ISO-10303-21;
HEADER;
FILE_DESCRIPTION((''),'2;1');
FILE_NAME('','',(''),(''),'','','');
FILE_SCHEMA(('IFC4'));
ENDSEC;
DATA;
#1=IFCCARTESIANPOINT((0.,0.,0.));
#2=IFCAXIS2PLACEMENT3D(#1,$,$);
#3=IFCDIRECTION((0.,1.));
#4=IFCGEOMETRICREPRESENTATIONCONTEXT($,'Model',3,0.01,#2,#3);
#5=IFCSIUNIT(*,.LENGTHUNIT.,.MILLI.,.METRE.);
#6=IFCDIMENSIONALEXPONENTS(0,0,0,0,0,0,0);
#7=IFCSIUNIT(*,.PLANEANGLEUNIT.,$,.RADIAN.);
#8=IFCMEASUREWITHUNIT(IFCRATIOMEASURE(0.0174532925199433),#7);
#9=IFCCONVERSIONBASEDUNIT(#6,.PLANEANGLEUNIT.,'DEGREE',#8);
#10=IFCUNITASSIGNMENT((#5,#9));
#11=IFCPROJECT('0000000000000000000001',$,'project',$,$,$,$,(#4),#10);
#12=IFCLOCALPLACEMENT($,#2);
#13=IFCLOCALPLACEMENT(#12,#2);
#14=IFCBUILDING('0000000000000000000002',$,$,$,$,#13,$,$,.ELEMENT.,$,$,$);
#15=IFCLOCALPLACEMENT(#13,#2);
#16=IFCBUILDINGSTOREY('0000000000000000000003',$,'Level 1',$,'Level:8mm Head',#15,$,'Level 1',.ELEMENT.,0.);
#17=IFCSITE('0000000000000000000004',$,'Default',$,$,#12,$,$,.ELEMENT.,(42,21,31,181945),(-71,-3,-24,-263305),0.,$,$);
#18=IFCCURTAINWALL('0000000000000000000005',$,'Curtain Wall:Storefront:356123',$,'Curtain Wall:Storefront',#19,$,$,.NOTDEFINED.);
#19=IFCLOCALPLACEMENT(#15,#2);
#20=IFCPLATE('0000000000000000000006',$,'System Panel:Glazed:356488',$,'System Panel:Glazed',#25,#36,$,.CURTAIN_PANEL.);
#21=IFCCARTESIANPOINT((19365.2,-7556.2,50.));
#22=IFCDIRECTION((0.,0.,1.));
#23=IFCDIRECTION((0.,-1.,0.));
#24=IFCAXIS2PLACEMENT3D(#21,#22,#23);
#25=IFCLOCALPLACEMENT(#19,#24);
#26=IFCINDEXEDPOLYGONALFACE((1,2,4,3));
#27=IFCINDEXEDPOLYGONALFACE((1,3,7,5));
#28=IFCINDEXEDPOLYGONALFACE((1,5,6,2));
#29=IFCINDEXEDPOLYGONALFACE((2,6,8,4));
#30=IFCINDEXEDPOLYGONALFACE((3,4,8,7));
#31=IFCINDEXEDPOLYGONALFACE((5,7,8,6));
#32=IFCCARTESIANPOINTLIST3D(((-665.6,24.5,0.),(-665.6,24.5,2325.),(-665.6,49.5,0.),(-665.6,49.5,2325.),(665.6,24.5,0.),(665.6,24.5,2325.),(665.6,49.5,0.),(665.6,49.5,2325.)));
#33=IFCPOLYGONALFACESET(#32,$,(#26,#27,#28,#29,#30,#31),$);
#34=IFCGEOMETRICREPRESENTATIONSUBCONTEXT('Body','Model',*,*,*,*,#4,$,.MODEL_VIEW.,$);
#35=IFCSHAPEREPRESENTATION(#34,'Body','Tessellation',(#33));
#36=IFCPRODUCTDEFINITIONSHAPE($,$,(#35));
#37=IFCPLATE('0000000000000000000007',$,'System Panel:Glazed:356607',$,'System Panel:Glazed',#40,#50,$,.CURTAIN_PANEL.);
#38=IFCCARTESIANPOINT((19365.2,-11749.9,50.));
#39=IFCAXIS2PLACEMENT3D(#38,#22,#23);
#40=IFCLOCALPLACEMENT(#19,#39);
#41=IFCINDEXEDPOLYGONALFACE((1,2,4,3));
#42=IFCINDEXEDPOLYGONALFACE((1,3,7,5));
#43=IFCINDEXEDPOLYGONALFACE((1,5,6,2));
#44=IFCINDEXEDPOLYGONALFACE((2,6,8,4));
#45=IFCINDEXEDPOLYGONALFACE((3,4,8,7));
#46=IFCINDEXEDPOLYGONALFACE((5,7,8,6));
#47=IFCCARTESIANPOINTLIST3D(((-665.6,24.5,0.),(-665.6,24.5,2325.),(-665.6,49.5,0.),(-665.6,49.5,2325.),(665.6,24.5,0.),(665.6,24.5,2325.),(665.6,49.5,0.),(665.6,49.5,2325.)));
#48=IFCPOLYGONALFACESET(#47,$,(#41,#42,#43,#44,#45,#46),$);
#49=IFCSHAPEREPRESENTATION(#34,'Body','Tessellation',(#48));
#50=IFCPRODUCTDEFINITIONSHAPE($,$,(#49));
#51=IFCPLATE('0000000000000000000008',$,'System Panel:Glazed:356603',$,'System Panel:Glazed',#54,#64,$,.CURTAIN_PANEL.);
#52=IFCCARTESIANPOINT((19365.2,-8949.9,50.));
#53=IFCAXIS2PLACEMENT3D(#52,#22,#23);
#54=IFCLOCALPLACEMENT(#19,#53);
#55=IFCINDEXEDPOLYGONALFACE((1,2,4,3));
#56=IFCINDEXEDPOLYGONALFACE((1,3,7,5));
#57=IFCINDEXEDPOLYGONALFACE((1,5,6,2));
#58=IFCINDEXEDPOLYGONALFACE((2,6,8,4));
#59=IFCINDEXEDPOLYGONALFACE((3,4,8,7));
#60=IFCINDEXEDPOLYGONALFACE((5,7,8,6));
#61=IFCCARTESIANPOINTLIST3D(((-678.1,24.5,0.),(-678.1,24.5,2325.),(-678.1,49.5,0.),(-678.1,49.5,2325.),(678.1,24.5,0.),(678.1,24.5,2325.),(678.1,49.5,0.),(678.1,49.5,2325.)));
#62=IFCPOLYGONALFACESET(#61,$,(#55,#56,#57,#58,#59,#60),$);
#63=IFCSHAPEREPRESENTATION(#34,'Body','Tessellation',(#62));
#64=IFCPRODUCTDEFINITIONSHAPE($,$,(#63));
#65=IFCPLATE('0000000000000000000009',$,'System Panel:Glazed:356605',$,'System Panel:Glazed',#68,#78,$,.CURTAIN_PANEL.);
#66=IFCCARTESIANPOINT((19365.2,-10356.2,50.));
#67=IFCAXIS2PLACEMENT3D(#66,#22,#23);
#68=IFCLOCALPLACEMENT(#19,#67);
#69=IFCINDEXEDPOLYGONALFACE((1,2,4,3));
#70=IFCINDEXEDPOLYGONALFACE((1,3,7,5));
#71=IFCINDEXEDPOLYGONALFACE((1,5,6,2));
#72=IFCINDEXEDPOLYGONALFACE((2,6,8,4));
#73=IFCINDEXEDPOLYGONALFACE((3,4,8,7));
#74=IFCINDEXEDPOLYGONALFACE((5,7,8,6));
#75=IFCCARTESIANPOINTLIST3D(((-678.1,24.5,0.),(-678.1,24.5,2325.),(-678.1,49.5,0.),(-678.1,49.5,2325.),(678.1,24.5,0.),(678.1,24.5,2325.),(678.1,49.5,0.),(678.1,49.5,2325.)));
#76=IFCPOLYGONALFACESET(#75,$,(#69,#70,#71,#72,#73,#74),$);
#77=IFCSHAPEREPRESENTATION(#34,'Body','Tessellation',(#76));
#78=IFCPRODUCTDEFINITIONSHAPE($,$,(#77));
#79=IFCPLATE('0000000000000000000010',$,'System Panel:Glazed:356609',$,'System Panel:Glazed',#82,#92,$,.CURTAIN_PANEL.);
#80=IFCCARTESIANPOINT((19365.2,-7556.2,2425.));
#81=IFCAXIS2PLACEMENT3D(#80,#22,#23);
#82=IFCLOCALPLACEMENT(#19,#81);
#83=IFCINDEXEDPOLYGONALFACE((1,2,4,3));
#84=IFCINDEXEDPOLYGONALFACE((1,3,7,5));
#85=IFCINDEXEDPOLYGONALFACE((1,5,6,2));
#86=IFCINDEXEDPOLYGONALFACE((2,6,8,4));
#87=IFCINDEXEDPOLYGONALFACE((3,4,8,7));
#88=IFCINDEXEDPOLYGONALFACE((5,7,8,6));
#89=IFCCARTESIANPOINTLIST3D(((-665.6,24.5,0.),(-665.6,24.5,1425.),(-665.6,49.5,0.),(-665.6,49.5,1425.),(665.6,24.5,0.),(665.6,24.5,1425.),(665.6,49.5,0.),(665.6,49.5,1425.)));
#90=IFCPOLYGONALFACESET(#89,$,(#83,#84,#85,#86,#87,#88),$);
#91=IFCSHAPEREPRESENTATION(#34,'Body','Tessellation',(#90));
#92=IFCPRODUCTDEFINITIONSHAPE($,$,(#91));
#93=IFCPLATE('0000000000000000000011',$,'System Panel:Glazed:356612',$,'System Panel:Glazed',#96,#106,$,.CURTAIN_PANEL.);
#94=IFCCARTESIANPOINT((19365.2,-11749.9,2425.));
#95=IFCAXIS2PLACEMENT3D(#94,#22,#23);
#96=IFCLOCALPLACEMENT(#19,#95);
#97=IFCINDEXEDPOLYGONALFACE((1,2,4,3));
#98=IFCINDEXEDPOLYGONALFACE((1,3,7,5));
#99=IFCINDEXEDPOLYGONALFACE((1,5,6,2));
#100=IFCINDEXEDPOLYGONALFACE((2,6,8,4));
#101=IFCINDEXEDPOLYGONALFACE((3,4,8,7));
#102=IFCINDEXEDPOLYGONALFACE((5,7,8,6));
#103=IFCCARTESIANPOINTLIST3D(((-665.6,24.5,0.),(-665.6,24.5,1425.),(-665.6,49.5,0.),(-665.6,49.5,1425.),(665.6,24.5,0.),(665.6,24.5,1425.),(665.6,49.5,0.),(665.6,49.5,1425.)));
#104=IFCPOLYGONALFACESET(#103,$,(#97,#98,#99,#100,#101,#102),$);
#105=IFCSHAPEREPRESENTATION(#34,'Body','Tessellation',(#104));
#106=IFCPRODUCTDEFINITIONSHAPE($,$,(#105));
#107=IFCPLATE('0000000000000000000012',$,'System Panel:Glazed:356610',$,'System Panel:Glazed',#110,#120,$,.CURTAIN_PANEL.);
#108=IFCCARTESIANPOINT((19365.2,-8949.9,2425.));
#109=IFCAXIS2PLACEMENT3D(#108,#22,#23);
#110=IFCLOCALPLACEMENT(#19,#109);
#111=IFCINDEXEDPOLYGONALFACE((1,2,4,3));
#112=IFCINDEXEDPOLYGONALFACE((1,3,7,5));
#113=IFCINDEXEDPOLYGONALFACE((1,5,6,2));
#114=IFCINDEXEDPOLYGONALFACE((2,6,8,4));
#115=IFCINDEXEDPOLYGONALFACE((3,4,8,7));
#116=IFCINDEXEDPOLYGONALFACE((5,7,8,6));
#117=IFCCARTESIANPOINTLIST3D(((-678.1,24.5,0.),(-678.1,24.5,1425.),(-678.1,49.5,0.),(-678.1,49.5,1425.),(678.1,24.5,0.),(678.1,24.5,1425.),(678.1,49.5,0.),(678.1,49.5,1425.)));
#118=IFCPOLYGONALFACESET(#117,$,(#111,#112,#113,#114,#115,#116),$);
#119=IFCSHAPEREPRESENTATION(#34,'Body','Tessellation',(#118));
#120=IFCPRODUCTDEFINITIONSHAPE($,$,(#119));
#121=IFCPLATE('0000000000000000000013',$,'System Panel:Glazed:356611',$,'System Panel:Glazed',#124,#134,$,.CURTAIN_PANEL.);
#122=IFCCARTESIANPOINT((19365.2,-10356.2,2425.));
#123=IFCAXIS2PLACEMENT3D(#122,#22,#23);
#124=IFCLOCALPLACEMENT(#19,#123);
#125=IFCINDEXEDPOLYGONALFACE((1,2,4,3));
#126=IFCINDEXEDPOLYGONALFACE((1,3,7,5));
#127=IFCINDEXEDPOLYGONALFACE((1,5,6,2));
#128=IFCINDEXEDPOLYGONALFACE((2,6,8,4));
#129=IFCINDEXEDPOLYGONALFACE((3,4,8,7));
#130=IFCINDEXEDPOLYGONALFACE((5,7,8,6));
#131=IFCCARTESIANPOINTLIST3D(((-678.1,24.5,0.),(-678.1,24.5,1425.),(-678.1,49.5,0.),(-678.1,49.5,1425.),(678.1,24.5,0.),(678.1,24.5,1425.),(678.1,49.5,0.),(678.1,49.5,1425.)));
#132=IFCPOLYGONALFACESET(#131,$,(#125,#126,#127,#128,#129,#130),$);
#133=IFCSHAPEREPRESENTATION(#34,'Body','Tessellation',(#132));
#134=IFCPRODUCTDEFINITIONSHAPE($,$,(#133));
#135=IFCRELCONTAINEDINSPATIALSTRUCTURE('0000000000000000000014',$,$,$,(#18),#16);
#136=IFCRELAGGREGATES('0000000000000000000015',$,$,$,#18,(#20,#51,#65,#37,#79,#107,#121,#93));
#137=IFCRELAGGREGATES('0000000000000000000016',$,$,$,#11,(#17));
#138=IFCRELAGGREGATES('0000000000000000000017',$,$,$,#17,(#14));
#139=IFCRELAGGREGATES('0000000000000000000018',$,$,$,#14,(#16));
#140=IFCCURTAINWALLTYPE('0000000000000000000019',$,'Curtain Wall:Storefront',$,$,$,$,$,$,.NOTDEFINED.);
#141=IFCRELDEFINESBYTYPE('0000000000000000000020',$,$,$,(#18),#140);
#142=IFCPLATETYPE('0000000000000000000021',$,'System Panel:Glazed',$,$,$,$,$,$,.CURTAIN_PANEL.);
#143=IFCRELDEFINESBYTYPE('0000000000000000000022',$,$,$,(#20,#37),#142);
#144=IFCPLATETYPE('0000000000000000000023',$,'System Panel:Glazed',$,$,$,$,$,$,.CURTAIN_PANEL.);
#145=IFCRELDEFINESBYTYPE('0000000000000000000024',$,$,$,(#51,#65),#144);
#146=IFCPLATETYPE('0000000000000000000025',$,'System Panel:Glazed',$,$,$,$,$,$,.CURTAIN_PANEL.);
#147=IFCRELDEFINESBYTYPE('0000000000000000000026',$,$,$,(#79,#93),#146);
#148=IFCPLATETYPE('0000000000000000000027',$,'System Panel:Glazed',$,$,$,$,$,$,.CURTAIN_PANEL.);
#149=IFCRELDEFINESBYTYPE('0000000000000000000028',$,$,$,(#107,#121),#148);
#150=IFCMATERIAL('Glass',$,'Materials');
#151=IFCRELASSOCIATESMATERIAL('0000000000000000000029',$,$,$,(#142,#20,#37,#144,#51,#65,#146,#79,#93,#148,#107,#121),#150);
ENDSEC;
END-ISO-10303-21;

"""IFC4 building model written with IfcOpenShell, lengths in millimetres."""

from ifc_helpers import new_model, entity, si_unit, converted_unit, direction, frame, origin, place, context, subcontext, project, spatial, indexed_curve, outline, extrude, shape, source, transform, mapped, material, type_object, type_shapes, element, aggregate, save


model = new_model("IFC4")

# Units and contexts
model_context = context("Model", 3, precision=0.01, world=origin(), true_north=direction((0.0, 1.0)))
body_context = subcontext(model_context, "Body", "Model", "MODEL_VIEW")
footprint_context = subcontext(model_context, "FootPrint", "Model", "MODEL_VIEW")
ifc_project = project(units=[si_unit("LENGTHUNIT", "METRE", prefix="MILLI"), converted_unit("PLANEANGLEUNIT", "DEGREE", entity("IfcRatioMeasure", 0.0174532925199433), si_unit("PLANEANGLEUNIT", "RADIAN"), dimensions=[0, 0, 0, 0, 0, 0, 0])], contexts=[model_context])

# Site, building, storey
site_placement = place(None, origin())
site = spatial("IfcSite", under=ifc_project, at=site_placement, Name="Default", CompositionType="ELEMENT", RefLatitude=(42, 21, 31, 181945), RefLongitude=(-71, -3, -24, -263305), RefElevation=0.0)
building_placement = place(site_placement, origin())
building = spatial("IfcBuilding", under=site, at=building_placement, CompositionType="ELEMENT")
storey_placement = place(building_placement, origin())
storey = spatial("IfcBuildingStorey", under=building, at=storey_placement, Name="Level 1", ObjectType="Level:8mm Head", LongName="Level 1", CompositionType="ELEMENT", Elevation=0.0)

# Shared definitions
curtain_wall_type_1 = type_object("IfcCurtainWallType", Name="Curtain Wall:Storefront", PredefinedType="NOTDEFINED")

# Curtain wall
curtain_wall_1_placement = place(storey_placement, origin())
curtain_wall_1 = element("IfcCurtainWall", 1, at=curtain_wall_1_placement, inside=storey, type_object=curtain_wall_type_1, Name="Curtain Wall:Storefront:356123", ObjectType="Curtain Wall:Storefront", PredefinedType="NOTDEFINED")

# Plates
ifc_material_1 = material(Name="Glass", Category="Materials")
plate_type_1 = type_object("IfcPlateType", Name="System Panel:Glazed", PredefinedType="CURTAIN_PANEL", material=ifc_material_1)
shared_shape_1 = source(origin(), body_context, "Body", "SweptSolid", [
    extrude(outline(indexed_curve([(-12.5, -665.6), (12.5, -665.6), (12.5, 665.6), (-12.5, 665.6), (-12.5, -665.6)], self_intersect=False)), frame((0.0, 37.0, 0.0), z_axis=(0.0, 0.0, 1.0), x_axis=(0.0, 1.0, 0.0)), (0.0, 0.0, 1.0), 2325.0),
])
shared_shape_2 = source(origin(), footprint_context, "FootPrint", "Curve2D", [
    entity("IfcIndexedPolyCurve", entity("IfcCartesianPointList2D", [[665.6, 24.5], [665.6, 49.5], [-665.6, 49.5], [-665.6, 24.5], [665.6, 24.5]]), None, False),
])
type_shapes(plate_type_1, [shared_shape_1, shared_shape_2])
plate_1_placement = place(curtain_wall_1_placement, frame((19365.2, -7556.2, 50.0), z_axis=(0.0, 0.0, 1.0), x_axis=(0.0, -1.0, 0.0)))
plate_1 = element("IfcPlate", 2, at=plate_1_placement, type_object=plate_type_1, material=ifc_material_1, Name="System Panel:Glazed:356488", ObjectType="System Panel:Glazed", PredefinedType="CURTAIN_PANEL", shapes=[
    shape(body_context, "Body", "MappedRepresentation", [mapped(shared_shape_1, transform((0.0, 0.0, 0.0), scale=1.0))]),
    shape(body_context, "Body", "MappedRepresentation", [mapped(shared_shape_2, transform((0.0, 0.0, 0.0), scale=1.0))]),
])
plate_2_placement = place(curtain_wall_1_placement, frame((19365.2, -11749.9, 50.0), z_axis=(0.0, 0.0, 1.0), x_axis=(0.0, -1.0, 0.0)))
plate_2 = element("IfcPlate", 3, at=plate_2_placement, type_object=plate_type_1, material=ifc_material_1, Name="System Panel:Glazed:356607", ObjectType="System Panel:Glazed", PredefinedType="CURTAIN_PANEL", shapes=[
    shape(body_context, "Body", "MappedRepresentation", [mapped(shared_shape_1, transform((0.0, 0.0, 0.0), scale=1.0))]),
    shape(body_context, "Body", "MappedRepresentation", [mapped(shared_shape_2, transform((0.0, 0.0, 0.0), scale=1.0))]),
])
plate_type_2 = type_object("IfcPlateType", Name="System Panel:Glazed", PredefinedType="CURTAIN_PANEL", material=ifc_material_1)
shared_shape_3 = source(origin(), body_context, "Body", "SweptSolid", [
    extrude(outline(indexed_curve([(-12.5, -678.1), (12.5, -678.1), (12.5, 678.1), (-12.5, 678.1), (-12.5, -678.1)], self_intersect=False)), frame((0.0, 37.0, 0.0), z_axis=(0.0, 0.0, 1.0), x_axis=(0.0, 1.0, 0.0)), (0.0, 0.0, 1.0), 2325.0),
])
shared_shape_4 = source(origin(), footprint_context, "FootPrint", "Curve2D", [
    entity("IfcIndexedPolyCurve", entity("IfcCartesianPointList2D", [[678.1, 24.5], [678.1, 49.5], [-678.1, 49.5], [-678.1, 24.5], [678.1, 24.5]]), None, False),
])
type_shapes(plate_type_2, [shared_shape_3, shared_shape_4])
plate_3_placement = place(curtain_wall_1_placement, frame((19365.2, -8949.9, 50.0), z_axis=(0.0, 0.0, 1.0), x_axis=(0.0, -1.0, 0.0)))
plate_3 = element("IfcPlate", 4, at=plate_3_placement, type_object=plate_type_2, material=ifc_material_1, Name="System Panel:Glazed:356603", ObjectType="System Panel:Glazed", PredefinedType="CURTAIN_PANEL", shapes=[
    shape(body_context, "Body", "MappedRepresentation", [mapped(shared_shape_3, transform((0.0, 0.0, 0.0), scale=1.0))]),
    shape(body_context, "Body", "MappedRepresentation", [mapped(shared_shape_4, transform((0.0, 0.0, 0.0), scale=1.0))]),
])
plate_4_placement = place(curtain_wall_1_placement, frame((19365.2, -10356.2, 50.0), z_axis=(0.0, 0.0, 1.0), x_axis=(0.0, -1.0, 0.0)))
plate_4 = element("IfcPlate", 5, at=plate_4_placement, type_object=plate_type_2, material=ifc_material_1, Name="System Panel:Glazed:356605", ObjectType="System Panel:Glazed", PredefinedType="CURTAIN_PANEL", shapes=[
    shape(body_context, "Body", "MappedRepresentation", [mapped(shared_shape_3, transform((0.0, 0.0, 0.0), scale=1.0))]),
    shape(body_context, "Body", "MappedRepresentation", [mapped(shared_shape_4, transform((0.0, 0.0, 0.0), scale=1.0))]),
])
plate_type_3 = type_object("IfcPlateType", Name="System Panel:Glazed", PredefinedType="CURTAIN_PANEL", material=ifc_material_1)
shared_shape_5 = source(origin(), body_context, "Body", "SweptSolid", [
    extrude(outline(indexed_curve([(-12.5, -665.6), (12.5, -665.6), (12.5, 665.6), (-12.5, 665.6), (-12.5, -665.6)], self_intersect=False)), frame((0.0, 37.0, 0.0), z_axis=(0.0, 0.0, 1.0), x_axis=(0.0, 1.0, 0.0)), (0.0, 0.0, 1.0), 1425.0),
])
shared_shape_6 = source(origin(), footprint_context, "FootPrint", "Curve2D", [
    entity("IfcIndexedPolyCurve", entity("IfcCartesianPointList2D", [[665.6, 24.5], [665.6, 49.5], [-665.6, 49.5], [-665.6, 24.5], [665.6, 24.5]]), None, False),
])
type_shapes(plate_type_3, [shared_shape_5, shared_shape_6])
plate_5_placement = place(curtain_wall_1_placement, frame((19365.2, -7556.2, 2425.0), z_axis=(0.0, 0.0, 1.0), x_axis=(0.0, -1.0, 0.0)))
plate_5 = element("IfcPlate", 6, at=plate_5_placement, type_object=plate_type_3, material=ifc_material_1, Name="System Panel:Glazed:356609", ObjectType="System Panel:Glazed", PredefinedType="CURTAIN_PANEL", shapes=[
    shape(body_context, "Body", "MappedRepresentation", [mapped(shared_shape_5, transform((0.0, 0.0, 0.0), scale=1.0))]),
    shape(body_context, "Body", "MappedRepresentation", [mapped(shared_shape_6, transform((0.0, 0.0, 0.0), scale=1.0))]),
])
plate_6_placement = place(curtain_wall_1_placement, frame((19365.2, -11749.9, 2425.0), z_axis=(0.0, 0.0, 1.0), x_axis=(0.0, -1.0, 0.0)))
plate_6 = element("IfcPlate", 7, at=plate_6_placement, type_object=plate_type_3, material=ifc_material_1, Name="System Panel:Glazed:356612", ObjectType="System Panel:Glazed", PredefinedType="CURTAIN_PANEL", shapes=[
    shape(body_context, "Body", "MappedRepresentation", [mapped(shared_shape_5, transform((0.0, 0.0, 0.0), scale=1.0))]),
    shape(body_context, "Body", "MappedRepresentation", [mapped(shared_shape_6, transform((0.0, 0.0, 0.0), scale=1.0))]),
])
plate_type_4 = type_object("IfcPlateType", Name="System Panel:Glazed", PredefinedType="CURTAIN_PANEL", material=ifc_material_1)
shared_shape_7 = source(origin(), body_context, "Body", "SweptSolid", [
    extrude(outline(indexed_curve([(-12.5, -678.1), (12.5, -678.1), (12.5, 678.1), (-12.5, 678.1), (-12.5, -678.1)], self_intersect=False)), frame((0.0, 37.0, 0.0), z_axis=(0.0, 0.0, 1.0), x_axis=(0.0, 1.0, 0.0)), (0.0, 0.0, 1.0), 1425.0),
])
shared_shape_8 = source(origin(), footprint_context, "FootPrint", "Curve2D", [
    entity("IfcIndexedPolyCurve", entity("IfcCartesianPointList2D", [[678.1, 24.5], [678.1, 49.5], [-678.1, 49.5], [-678.1, 24.5], [678.1, 24.5]]), None, False),
])
type_shapes(plate_type_4, [shared_shape_7, shared_shape_8])
plate_7_placement = place(curtain_wall_1_placement, frame((19365.2, -8949.9, 2425.0), z_axis=(0.0, 0.0, 1.0), x_axis=(0.0, -1.0, 0.0)))
plate_7 = element("IfcPlate", 8, at=plate_7_placement, type_object=plate_type_4, material=ifc_material_1, Name="System Panel:Glazed:356610", ObjectType="System Panel:Glazed", PredefinedType="CURTAIN_PANEL", shapes=[
    shape(body_context, "Body", "MappedRepresentation", [mapped(shared_shape_7, transform((0.0, 0.0, 0.0), scale=1.0))]),
    shape(body_context, "Body", "MappedRepresentation", [mapped(shared_shape_8, transform((0.0, 0.0, 0.0), scale=1.0))]),
])
plate_8_placement = place(curtain_wall_1_placement, frame((19365.2, -10356.2, 2425.0), z_axis=(0.0, 0.0, 1.0), x_axis=(0.0, -1.0, 0.0)))
plate_8 = element("IfcPlate", 9, at=plate_8_placement, type_object=plate_type_4, material=ifc_material_1, Name="System Panel:Glazed:356611", ObjectType="System Panel:Glazed", PredefinedType="CURTAIN_PANEL", shapes=[
    shape(body_context, "Body", "MappedRepresentation", [mapped(shared_shape_7, transform((0.0, 0.0, 0.0), scale=1.0))]),
    shape(body_context, "Body", "MappedRepresentation", [mapped(shared_shape_8, transform((0.0, 0.0, 0.0), scale=1.0))]),
])
aggregate(curtain_wall_1, [plate_1, plate_3, plate_4, plate_2, plate_5, plate_7, plate_8, plate_6])

save(model, "model.ifc")
